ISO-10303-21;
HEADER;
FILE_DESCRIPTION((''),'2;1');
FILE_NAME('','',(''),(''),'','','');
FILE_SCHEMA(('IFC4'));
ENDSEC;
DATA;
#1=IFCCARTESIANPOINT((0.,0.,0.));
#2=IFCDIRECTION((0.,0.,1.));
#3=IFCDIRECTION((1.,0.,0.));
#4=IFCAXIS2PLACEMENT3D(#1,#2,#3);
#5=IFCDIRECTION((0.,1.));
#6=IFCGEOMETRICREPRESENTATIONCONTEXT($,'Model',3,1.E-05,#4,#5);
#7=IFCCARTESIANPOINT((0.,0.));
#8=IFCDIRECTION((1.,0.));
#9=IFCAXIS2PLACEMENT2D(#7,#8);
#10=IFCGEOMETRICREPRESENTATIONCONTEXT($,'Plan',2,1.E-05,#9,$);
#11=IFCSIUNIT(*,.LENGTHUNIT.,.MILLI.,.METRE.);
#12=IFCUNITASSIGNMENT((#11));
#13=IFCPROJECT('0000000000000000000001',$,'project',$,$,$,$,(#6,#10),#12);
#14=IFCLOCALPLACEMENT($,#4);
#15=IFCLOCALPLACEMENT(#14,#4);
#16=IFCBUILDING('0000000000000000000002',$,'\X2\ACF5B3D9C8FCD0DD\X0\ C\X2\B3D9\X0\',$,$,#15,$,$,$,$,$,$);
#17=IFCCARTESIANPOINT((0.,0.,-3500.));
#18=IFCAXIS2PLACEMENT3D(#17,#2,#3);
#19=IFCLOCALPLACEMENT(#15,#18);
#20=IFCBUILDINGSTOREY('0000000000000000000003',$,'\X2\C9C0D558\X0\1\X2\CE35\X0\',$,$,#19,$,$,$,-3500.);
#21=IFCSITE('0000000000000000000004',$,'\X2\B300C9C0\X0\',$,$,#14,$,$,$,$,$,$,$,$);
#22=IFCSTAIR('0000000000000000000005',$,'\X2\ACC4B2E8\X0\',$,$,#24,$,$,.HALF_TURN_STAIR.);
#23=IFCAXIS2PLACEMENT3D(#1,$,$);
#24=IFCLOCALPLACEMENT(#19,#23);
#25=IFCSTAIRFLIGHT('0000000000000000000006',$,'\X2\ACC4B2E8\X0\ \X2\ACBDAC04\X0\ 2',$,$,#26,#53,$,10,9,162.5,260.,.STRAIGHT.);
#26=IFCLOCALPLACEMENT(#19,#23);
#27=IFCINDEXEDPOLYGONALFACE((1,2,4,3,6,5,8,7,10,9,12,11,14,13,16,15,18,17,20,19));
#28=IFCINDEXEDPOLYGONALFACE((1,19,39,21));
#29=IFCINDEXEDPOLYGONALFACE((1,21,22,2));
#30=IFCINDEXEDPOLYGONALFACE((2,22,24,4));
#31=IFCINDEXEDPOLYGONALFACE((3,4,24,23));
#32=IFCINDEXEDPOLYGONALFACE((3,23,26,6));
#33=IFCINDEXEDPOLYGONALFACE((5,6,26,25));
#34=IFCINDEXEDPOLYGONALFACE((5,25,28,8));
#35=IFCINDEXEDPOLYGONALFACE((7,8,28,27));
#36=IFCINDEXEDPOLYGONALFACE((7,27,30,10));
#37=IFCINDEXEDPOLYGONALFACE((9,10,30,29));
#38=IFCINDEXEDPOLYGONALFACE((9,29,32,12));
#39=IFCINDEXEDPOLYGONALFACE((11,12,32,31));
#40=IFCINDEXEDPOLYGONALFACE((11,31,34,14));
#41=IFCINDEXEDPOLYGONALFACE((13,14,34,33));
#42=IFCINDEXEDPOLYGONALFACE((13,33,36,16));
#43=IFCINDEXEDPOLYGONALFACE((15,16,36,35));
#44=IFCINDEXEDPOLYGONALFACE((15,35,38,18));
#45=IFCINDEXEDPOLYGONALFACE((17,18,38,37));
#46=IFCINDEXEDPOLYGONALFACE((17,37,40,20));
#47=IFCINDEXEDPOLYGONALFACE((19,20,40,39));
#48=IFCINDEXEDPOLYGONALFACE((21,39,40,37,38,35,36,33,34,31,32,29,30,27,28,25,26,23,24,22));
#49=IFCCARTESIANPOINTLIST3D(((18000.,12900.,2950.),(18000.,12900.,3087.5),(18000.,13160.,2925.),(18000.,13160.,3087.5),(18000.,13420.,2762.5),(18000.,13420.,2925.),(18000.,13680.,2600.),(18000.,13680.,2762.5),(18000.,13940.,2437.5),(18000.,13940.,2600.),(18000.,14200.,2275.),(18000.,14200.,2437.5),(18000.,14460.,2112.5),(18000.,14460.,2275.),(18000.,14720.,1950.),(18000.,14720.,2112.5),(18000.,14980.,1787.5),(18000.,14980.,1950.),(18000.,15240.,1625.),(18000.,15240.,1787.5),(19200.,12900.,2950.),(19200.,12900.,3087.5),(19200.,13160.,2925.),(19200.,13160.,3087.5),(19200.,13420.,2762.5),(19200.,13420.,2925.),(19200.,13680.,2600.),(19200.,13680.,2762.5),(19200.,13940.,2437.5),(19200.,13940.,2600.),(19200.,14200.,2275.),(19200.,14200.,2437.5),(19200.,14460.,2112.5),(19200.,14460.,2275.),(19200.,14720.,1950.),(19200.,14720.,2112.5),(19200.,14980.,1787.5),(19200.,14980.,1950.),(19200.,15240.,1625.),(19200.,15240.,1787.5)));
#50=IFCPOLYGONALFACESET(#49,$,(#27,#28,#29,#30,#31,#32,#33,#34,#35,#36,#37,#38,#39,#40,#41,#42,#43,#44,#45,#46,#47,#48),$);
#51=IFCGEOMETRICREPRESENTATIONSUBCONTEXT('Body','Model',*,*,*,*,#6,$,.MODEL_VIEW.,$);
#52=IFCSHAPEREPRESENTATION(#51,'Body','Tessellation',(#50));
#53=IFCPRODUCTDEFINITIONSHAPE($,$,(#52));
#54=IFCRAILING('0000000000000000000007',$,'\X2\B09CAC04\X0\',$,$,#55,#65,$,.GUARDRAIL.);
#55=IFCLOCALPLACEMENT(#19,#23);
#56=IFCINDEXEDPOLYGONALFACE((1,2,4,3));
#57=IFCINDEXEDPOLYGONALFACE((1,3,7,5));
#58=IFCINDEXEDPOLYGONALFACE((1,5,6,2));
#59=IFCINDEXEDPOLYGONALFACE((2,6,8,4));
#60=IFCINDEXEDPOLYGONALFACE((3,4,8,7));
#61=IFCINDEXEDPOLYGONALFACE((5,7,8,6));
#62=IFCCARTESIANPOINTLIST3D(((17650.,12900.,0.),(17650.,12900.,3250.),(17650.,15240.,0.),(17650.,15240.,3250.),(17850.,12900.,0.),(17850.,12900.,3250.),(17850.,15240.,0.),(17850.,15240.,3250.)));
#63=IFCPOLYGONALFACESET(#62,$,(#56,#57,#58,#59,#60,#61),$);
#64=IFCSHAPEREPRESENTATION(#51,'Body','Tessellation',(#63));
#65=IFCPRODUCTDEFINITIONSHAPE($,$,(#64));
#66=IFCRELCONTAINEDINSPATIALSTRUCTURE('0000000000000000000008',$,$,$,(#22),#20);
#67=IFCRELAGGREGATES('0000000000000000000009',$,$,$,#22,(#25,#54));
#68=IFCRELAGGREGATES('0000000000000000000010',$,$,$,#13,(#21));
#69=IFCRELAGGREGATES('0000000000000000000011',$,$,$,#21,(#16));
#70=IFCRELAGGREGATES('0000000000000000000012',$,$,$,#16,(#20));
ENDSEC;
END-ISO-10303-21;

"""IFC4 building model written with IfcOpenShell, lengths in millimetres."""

from ifc_helpers import new_model, si_unit, direction, frame, origin_with_axes, origin_2d_with_axis, place, context, subcontext, project, spatial, polyline, outline, extrude, element, aggregate, save


model = new_model("IFC4")

# Units and contexts
model_context = context("Model", 3, precision=1e-05, world=origin_with_axes(), true_north=direction((0.0, 1.0)))
plan_context = context("Plan", 2, precision=1e-05, world=origin_2d_with_axis())
body_context = subcontext(model_context, "Body", "Model", "MODEL_VIEW")
ifc_project = project(units=[si_unit("LENGTHUNIT", "METRE", prefix="MILLI")], contexts=[model_context, plan_context])

# Site, building, storey
site_placement = place(None, origin_with_axes())
site = spatial("IfcSite", under=ifc_project, at=site_placement, Name="대지")
building_placement = place(site_placement, origin_with_axes())
building = spatial("IfcBuilding", under=site, at=building_placement, Name="공동주택 C동")
storey_placement = place(building_placement, frame((0.0, 0.0, -3500.0), z_axis=(0.0, 0.0, 1.0), x_axis=(1.0, 0.0, 0.0)))
storey = spatial("IfcBuildingStorey", under=building, at=storey_placement, Name="지하1층", Elevation=-3500.0)

# Stair
stair_placement = place(storey_placement, origin_with_axes())
stair = element("IfcStair", 1, at=stair_placement, inside=storey, Name="계단", PredefinedType="HALF_TURN_STAIR")

# Stair flight
stair_flight_1_placement = place(stair_placement, origin_with_axes())
stair_flight_1 = element("IfcStairFlight", 2, at=stair_flight_1_placement, Name="계단 경간 2", NumberOfRisers=10, NumberOfTreads=9, PredefinedType="STRAIGHT", RiserHeight=162.5, TreadLength=260.0, context=body_context, shape_type="SweptSolid", body=[
    extrude(outline(polyline([(0.0, 0.0), (0.0, 162.5), (260.0, 162.5), (260.0, 325.0), (520.0, 325.0), (520.0, 487.5), (780.0, 487.5), (780.0, 650.0), (1040.0, 650.0), (1040.0, 812.5), (1300.0, 812.5), (1300.0, 975.0), (1560.0, 975.0), (1560.0, 1137.5), (1820.0, 1137.5), (1820.0, 1300.0), (2080.0, 1300.0), (2080.0, 1462.5), (2340.0, 1462.5), (2340.0, 1625.0), (2340.0, 1325.0), (0.0, 0.0)])), frame((19200.0, 15240.0, 1625.0), z_axis=(-1.0, 0.0, 0.0), x_axis=(0.0, -1.0, 0.0)), (0.0, 0.0, 1.0), 1200.0),
])

# Railing
railing_placement = place(stair_placement, origin_with_axes())
railing = element("IfcRailing", 3, at=railing_placement, Name="난간", PredefinedType="GUARDRAIL", context=body_context, shape_type="SweptSolid", body=[
    extrude(outline(polyline([(17650.0, 12900.0), (17850.0, 12900.0), (17850.0, 15240.0), (17650.0, 15240.0), (17650.0, 12900.0)])), origin_with_axes(), (0.0, 0.0, 1.0), 3250.0),
])
aggregate(stair, [stair_flight_1, railing])

save(model, "model.ifc")
